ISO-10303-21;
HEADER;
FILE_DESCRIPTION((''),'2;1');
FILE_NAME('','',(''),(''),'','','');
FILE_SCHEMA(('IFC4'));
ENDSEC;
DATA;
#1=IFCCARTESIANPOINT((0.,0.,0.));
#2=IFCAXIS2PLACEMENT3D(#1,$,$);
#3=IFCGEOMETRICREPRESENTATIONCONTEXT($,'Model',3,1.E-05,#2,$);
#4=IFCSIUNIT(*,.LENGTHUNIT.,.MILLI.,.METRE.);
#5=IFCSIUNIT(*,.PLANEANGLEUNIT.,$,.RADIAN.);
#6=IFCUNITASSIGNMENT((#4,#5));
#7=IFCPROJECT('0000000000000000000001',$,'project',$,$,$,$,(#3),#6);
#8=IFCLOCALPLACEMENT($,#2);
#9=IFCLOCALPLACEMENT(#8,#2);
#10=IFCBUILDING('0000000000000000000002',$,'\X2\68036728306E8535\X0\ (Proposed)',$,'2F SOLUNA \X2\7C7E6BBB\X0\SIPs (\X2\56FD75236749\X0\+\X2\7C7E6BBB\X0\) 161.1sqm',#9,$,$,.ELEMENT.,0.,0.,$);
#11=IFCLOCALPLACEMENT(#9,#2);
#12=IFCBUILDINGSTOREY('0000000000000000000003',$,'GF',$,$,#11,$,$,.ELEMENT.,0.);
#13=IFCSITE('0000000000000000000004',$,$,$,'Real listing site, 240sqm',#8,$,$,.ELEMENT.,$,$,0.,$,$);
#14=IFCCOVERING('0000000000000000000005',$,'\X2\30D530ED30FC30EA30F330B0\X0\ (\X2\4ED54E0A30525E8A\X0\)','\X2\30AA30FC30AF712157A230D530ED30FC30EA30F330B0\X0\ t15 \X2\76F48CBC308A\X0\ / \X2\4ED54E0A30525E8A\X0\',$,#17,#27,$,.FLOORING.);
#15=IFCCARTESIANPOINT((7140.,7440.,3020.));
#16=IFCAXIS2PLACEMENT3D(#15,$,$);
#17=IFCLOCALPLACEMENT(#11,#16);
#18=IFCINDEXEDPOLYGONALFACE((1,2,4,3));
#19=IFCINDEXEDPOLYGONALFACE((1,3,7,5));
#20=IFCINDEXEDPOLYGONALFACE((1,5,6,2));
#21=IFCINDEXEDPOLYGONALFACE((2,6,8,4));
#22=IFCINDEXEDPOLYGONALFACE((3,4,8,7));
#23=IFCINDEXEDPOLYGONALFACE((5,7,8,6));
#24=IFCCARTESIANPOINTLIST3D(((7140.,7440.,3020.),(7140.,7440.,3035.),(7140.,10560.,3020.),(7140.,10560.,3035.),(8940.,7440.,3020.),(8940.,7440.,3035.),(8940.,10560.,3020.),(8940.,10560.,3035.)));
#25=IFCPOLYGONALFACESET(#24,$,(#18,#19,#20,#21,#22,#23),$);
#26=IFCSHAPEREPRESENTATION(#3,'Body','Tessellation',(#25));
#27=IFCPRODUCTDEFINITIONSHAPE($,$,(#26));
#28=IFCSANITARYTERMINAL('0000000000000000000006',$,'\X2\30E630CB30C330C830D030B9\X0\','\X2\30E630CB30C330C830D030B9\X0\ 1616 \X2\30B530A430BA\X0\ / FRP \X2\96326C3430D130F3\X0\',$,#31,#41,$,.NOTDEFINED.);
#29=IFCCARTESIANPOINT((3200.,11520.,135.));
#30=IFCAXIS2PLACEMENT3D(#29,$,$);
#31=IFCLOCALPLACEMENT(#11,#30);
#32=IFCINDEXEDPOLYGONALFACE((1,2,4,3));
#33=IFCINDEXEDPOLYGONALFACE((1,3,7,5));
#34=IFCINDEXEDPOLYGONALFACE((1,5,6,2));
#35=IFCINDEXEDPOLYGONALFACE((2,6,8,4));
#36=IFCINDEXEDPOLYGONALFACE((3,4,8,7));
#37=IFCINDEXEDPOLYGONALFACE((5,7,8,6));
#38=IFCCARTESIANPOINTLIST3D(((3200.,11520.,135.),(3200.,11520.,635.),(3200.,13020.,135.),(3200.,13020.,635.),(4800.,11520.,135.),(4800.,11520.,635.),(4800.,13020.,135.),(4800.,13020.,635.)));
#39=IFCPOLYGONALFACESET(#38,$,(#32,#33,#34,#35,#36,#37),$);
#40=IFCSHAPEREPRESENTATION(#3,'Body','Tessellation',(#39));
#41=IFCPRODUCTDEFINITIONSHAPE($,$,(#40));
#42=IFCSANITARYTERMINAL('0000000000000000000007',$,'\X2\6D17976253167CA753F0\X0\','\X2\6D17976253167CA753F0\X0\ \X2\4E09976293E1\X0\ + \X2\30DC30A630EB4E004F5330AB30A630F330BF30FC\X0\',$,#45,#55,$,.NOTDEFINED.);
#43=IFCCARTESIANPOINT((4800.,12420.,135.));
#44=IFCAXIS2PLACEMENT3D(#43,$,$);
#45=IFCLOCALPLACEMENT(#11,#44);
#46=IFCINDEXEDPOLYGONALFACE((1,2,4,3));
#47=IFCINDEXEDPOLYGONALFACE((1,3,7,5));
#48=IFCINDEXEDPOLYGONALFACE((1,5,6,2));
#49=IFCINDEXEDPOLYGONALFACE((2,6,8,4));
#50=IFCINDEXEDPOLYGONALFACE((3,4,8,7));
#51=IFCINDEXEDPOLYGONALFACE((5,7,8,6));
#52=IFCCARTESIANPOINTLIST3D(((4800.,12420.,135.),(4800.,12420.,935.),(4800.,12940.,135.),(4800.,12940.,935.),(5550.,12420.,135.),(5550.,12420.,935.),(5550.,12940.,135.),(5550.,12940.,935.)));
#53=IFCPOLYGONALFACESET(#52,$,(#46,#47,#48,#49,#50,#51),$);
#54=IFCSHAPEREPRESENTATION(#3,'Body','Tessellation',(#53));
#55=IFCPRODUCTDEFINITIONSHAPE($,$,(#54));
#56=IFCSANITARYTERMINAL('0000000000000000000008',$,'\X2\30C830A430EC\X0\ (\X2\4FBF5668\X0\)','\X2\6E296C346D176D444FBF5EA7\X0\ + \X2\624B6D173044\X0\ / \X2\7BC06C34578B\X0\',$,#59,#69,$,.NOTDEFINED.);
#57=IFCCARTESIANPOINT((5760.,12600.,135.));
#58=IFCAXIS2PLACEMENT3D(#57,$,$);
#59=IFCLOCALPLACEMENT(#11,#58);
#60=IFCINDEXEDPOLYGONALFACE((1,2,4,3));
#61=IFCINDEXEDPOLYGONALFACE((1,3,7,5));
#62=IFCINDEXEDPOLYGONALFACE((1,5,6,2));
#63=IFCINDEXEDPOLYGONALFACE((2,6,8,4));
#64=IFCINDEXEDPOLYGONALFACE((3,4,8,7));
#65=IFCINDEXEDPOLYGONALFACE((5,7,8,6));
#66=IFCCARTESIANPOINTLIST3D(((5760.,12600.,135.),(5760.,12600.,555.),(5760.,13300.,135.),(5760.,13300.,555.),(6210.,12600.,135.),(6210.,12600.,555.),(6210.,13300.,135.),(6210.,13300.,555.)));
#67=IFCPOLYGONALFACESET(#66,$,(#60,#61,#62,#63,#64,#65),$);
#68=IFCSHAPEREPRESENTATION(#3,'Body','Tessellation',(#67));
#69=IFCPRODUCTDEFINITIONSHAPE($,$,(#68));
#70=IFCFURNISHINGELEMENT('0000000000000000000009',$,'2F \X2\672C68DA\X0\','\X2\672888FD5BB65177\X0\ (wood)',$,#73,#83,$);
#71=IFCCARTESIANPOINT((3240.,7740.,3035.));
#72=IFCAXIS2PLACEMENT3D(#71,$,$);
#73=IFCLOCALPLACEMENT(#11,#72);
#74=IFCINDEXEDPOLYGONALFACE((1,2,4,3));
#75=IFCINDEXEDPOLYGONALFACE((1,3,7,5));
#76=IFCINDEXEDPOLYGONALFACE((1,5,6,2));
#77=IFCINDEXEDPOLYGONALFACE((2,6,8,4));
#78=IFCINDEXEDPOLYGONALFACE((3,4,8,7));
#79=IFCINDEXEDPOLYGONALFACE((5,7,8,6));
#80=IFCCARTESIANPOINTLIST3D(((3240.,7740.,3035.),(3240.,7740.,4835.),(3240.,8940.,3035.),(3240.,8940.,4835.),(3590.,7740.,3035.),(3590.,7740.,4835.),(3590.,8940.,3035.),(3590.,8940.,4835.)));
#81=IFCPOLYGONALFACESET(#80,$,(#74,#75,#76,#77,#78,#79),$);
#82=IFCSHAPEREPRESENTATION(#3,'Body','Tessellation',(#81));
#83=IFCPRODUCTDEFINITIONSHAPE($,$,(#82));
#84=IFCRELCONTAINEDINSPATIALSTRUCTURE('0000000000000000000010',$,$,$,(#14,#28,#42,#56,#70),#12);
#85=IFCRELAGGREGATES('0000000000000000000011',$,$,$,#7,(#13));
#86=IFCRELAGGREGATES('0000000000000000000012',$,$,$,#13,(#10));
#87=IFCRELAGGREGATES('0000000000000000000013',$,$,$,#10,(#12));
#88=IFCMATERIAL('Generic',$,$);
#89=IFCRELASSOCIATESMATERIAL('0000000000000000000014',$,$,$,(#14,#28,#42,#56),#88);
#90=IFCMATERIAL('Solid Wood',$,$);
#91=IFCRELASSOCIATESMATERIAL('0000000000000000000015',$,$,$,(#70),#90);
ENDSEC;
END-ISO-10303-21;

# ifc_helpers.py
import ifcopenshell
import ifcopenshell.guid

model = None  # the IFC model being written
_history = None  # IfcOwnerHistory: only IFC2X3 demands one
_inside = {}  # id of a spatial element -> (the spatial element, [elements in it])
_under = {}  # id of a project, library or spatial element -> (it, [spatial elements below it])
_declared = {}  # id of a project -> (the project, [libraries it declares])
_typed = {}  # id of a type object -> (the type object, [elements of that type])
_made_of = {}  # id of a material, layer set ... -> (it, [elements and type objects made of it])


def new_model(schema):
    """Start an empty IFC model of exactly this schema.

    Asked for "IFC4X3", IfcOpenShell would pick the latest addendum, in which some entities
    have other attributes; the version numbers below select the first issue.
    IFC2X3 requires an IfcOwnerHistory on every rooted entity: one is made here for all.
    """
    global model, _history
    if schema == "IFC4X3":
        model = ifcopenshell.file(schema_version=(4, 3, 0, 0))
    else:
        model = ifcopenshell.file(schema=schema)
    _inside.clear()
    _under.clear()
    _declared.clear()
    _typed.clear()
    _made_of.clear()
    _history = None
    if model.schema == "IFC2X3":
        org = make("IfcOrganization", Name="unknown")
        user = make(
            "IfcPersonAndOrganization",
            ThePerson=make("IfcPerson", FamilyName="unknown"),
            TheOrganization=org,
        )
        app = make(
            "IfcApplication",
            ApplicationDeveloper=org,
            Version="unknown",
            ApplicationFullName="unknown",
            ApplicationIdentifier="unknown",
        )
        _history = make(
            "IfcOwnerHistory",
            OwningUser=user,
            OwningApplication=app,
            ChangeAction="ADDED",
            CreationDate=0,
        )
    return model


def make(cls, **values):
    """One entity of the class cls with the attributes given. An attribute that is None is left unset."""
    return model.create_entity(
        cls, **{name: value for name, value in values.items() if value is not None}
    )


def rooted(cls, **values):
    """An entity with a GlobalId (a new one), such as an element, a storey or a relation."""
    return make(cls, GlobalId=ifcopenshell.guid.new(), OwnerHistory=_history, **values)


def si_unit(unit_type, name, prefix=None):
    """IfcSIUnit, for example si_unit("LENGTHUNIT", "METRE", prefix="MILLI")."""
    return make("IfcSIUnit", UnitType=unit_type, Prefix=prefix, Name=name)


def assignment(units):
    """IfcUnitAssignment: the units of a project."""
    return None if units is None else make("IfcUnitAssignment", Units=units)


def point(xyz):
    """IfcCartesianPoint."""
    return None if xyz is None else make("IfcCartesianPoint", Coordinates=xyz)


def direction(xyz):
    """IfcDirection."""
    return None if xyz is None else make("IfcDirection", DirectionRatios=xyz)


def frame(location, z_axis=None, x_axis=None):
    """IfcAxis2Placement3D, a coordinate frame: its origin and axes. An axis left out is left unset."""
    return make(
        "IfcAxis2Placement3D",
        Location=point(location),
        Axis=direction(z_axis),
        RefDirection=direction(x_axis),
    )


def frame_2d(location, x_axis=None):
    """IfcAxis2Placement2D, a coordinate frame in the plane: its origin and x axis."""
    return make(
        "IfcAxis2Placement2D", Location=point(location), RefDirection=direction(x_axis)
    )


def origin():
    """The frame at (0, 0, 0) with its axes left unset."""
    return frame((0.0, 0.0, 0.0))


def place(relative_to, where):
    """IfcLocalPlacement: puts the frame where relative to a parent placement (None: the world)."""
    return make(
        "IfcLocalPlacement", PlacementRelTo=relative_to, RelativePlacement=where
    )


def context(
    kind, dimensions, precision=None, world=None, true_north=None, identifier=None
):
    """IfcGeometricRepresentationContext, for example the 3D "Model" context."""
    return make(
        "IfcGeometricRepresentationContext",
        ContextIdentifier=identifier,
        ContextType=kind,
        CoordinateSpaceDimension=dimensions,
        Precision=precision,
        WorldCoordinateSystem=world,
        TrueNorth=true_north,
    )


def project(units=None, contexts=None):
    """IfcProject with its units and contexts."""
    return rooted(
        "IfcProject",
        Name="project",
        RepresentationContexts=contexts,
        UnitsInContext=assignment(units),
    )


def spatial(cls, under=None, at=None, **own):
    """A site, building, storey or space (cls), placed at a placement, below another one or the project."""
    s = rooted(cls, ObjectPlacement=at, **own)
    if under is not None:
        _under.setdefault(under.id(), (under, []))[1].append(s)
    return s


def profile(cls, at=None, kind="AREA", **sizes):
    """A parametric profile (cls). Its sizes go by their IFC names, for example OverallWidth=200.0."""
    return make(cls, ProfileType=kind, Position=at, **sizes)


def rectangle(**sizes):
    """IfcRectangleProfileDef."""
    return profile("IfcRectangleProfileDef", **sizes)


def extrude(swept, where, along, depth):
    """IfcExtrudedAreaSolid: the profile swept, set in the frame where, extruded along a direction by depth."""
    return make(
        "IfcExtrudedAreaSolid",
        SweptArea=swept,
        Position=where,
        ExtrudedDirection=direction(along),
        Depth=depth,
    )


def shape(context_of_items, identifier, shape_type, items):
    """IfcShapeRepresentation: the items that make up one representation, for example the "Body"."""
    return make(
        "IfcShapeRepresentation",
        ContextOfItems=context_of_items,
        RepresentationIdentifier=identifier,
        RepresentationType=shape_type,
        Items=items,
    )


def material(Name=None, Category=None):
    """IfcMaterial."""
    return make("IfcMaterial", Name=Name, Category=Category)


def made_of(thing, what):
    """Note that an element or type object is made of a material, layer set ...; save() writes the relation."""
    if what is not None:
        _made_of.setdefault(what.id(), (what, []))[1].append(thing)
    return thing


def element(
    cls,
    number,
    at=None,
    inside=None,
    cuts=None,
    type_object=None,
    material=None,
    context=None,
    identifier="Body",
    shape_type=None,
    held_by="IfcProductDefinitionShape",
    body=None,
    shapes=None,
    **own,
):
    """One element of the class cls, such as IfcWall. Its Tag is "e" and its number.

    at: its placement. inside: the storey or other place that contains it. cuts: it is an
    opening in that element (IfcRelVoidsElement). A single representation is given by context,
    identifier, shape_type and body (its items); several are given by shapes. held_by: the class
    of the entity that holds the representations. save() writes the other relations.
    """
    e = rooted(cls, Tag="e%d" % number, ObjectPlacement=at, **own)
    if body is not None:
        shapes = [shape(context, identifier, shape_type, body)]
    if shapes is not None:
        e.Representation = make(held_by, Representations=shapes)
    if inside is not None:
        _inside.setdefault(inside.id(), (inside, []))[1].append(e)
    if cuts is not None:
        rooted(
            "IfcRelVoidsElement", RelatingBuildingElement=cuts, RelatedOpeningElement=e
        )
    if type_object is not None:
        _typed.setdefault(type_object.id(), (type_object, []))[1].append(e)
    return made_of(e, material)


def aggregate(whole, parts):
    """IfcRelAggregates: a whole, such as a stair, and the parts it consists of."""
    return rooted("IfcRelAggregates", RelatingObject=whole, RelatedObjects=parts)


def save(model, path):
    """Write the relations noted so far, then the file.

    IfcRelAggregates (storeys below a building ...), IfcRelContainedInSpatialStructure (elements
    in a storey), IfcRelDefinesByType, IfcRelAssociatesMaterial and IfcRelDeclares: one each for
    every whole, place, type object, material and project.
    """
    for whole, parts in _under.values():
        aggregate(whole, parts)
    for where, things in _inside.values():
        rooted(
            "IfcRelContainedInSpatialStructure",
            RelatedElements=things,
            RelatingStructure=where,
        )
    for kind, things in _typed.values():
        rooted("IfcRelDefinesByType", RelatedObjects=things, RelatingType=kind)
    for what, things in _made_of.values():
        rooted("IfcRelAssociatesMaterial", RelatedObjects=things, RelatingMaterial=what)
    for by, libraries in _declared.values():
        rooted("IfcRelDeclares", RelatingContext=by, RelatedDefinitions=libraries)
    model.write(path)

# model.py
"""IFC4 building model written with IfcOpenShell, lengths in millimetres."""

from ifc_helpers import new_model, si_unit, frame, frame_2d, origin, place, context, project, spatial, rectangle, extrude, material, element, save


model = new_model("IFC4")

# Units and contexts
model_context = context("Model", 3, precision=1e-05, world=origin())
ifc_project = project(units=[si_unit("LENGTHUNIT", "METRE", prefix="MILLI"), si_unit("PLANEANGLEUNIT", "RADIAN")], contexts=[model_context])

# Site, building, storey
site_placement = place(None, origin())
site = spatial("IfcSite", under=ifc_project, at=site_placement, ObjectType="Real listing site, 240sqm", CompositionType="ELEMENT", RefElevation=0.0)
building_placement = place(site_placement, origin())
building = spatial("IfcBuilding", under=site, at=building_placement, Name="栃木の蔵 (Proposed)", ObjectType="2F SOLUNA 籾殻SIPs (国産杉+籾殻) 161.1sqm", CompositionType="ELEMENT", ElevationOfRefHeight=0.0, ElevationOfTerrain=0.0)
storey_placement = place(building_placement, origin())
storey = spatial("IfcBuildingStorey", under=building, at=storey_placement, Name="GF", CompositionType="ELEMENT", Elevation=0.0)

# Shared definitions
ifc_material_1 = material(Name="Solid Wood")
ifc_material_2 = material(Name="Generic")

# Covering
covering_1_placement = place(storey_placement, frame((7140.0, 7440.0, 3020.0)))
element("IfcCovering", 1, at=covering_1_placement, inside=storey, material=ifc_material_2, Name="フローリング (仕上げ床)", Description="オーク無垢フローリング t15 直貼り / 仕上げ床", PredefinedType="FLOORING", context=model_context, shape_type="SweptSolid", body=[
    extrude(rectangle(XDim=1800.0, YDim=3120.0, at=frame_2d((900.0, 1560.0))), frame((7140.0, 7440.0, 3020.0)), (0.0, 0.0, 1.0), 15.0),
])

# Sanitary terminals
sanitary_terminal_1_placement = place(storey_placement, frame((3200.0, 11520.0, 135.0)))
element("IfcSanitaryTerminal", 2, at=sanitary_terminal_1_placement, inside=storey, material=ifc_material_2, Name="ユニットバス", Description="ユニットバス 1616 サイズ / FRP 防水パン", PredefinedType="NOTDEFINED", context=model_context, shape_type="SweptSolid", body=[
    extrude(rectangle(XDim=1600.0, YDim=1500.0, at=frame_2d((800.0, 750.0))), frame((3200.0, 11520.0, 135.0)), (0.0, 0.0, 1.0), 500.0),
])
sanitary_terminal_2_placement = place(storey_placement, frame((4800.0, 12420.0, 135.0)))
element("IfcSanitaryTerminal", 3, at=sanitary_terminal_2_placement, inside=storey, material=ifc_material_2, Name="洗面化粧台", Description="洗面化粧台 三面鏡 + ボウル一体カウンター", PredefinedType="NOTDEFINED", context=model_context, shape_type="SweptSolid", body=[
    extrude(rectangle(XDim=750.0, YDim=520.0, at=frame_2d((375.0, 260.0))), frame((4800.0, 12420.0, 135.0)), (0.0, 0.0, 1.0), 800.0),
])
sanitary_terminal_3_placement = place(storey_placement, frame((5760.0, 12600.0, 135.0)))
element("IfcSanitaryTerminal", 4, at=sanitary_terminal_3_placement, inside=storey, material=ifc_material_2, Name="トイレ (便器)", Description="温水洗浄便座 + 手洗い / 節水型", PredefinedType="NOTDEFINED", context=model_context, shape_type="SweptSolid", body=[
    extrude(rectangle(XDim=450.0, YDim=700.0, at=frame_2d((225.0, 350.0))), frame((5760.0, 12600.0, 135.0)), (0.0, 0.0, 1.0), 420.0),
])

# Furnishing element
furnishing_placement = place(storey_placement, frame((3240.0, 7740.0, 3035.0)))
element("IfcFurnishingElement", 5, at=furnishing_placement, inside=storey, material=ifc_material_1, Name="2F 本棚", Description="木製家具 (wood)", context=model_context, shape_type="SweptSolid", body=[
    extrude(rectangle(XDim=350.0, YDim=1200.0, at=frame_2d((175.0, 600.0))), frame((3240.0, 7740.0, 3035.0)), (0.0, 0.0, 1.0), 1800.0),
])

save(model, "model.ifc")
